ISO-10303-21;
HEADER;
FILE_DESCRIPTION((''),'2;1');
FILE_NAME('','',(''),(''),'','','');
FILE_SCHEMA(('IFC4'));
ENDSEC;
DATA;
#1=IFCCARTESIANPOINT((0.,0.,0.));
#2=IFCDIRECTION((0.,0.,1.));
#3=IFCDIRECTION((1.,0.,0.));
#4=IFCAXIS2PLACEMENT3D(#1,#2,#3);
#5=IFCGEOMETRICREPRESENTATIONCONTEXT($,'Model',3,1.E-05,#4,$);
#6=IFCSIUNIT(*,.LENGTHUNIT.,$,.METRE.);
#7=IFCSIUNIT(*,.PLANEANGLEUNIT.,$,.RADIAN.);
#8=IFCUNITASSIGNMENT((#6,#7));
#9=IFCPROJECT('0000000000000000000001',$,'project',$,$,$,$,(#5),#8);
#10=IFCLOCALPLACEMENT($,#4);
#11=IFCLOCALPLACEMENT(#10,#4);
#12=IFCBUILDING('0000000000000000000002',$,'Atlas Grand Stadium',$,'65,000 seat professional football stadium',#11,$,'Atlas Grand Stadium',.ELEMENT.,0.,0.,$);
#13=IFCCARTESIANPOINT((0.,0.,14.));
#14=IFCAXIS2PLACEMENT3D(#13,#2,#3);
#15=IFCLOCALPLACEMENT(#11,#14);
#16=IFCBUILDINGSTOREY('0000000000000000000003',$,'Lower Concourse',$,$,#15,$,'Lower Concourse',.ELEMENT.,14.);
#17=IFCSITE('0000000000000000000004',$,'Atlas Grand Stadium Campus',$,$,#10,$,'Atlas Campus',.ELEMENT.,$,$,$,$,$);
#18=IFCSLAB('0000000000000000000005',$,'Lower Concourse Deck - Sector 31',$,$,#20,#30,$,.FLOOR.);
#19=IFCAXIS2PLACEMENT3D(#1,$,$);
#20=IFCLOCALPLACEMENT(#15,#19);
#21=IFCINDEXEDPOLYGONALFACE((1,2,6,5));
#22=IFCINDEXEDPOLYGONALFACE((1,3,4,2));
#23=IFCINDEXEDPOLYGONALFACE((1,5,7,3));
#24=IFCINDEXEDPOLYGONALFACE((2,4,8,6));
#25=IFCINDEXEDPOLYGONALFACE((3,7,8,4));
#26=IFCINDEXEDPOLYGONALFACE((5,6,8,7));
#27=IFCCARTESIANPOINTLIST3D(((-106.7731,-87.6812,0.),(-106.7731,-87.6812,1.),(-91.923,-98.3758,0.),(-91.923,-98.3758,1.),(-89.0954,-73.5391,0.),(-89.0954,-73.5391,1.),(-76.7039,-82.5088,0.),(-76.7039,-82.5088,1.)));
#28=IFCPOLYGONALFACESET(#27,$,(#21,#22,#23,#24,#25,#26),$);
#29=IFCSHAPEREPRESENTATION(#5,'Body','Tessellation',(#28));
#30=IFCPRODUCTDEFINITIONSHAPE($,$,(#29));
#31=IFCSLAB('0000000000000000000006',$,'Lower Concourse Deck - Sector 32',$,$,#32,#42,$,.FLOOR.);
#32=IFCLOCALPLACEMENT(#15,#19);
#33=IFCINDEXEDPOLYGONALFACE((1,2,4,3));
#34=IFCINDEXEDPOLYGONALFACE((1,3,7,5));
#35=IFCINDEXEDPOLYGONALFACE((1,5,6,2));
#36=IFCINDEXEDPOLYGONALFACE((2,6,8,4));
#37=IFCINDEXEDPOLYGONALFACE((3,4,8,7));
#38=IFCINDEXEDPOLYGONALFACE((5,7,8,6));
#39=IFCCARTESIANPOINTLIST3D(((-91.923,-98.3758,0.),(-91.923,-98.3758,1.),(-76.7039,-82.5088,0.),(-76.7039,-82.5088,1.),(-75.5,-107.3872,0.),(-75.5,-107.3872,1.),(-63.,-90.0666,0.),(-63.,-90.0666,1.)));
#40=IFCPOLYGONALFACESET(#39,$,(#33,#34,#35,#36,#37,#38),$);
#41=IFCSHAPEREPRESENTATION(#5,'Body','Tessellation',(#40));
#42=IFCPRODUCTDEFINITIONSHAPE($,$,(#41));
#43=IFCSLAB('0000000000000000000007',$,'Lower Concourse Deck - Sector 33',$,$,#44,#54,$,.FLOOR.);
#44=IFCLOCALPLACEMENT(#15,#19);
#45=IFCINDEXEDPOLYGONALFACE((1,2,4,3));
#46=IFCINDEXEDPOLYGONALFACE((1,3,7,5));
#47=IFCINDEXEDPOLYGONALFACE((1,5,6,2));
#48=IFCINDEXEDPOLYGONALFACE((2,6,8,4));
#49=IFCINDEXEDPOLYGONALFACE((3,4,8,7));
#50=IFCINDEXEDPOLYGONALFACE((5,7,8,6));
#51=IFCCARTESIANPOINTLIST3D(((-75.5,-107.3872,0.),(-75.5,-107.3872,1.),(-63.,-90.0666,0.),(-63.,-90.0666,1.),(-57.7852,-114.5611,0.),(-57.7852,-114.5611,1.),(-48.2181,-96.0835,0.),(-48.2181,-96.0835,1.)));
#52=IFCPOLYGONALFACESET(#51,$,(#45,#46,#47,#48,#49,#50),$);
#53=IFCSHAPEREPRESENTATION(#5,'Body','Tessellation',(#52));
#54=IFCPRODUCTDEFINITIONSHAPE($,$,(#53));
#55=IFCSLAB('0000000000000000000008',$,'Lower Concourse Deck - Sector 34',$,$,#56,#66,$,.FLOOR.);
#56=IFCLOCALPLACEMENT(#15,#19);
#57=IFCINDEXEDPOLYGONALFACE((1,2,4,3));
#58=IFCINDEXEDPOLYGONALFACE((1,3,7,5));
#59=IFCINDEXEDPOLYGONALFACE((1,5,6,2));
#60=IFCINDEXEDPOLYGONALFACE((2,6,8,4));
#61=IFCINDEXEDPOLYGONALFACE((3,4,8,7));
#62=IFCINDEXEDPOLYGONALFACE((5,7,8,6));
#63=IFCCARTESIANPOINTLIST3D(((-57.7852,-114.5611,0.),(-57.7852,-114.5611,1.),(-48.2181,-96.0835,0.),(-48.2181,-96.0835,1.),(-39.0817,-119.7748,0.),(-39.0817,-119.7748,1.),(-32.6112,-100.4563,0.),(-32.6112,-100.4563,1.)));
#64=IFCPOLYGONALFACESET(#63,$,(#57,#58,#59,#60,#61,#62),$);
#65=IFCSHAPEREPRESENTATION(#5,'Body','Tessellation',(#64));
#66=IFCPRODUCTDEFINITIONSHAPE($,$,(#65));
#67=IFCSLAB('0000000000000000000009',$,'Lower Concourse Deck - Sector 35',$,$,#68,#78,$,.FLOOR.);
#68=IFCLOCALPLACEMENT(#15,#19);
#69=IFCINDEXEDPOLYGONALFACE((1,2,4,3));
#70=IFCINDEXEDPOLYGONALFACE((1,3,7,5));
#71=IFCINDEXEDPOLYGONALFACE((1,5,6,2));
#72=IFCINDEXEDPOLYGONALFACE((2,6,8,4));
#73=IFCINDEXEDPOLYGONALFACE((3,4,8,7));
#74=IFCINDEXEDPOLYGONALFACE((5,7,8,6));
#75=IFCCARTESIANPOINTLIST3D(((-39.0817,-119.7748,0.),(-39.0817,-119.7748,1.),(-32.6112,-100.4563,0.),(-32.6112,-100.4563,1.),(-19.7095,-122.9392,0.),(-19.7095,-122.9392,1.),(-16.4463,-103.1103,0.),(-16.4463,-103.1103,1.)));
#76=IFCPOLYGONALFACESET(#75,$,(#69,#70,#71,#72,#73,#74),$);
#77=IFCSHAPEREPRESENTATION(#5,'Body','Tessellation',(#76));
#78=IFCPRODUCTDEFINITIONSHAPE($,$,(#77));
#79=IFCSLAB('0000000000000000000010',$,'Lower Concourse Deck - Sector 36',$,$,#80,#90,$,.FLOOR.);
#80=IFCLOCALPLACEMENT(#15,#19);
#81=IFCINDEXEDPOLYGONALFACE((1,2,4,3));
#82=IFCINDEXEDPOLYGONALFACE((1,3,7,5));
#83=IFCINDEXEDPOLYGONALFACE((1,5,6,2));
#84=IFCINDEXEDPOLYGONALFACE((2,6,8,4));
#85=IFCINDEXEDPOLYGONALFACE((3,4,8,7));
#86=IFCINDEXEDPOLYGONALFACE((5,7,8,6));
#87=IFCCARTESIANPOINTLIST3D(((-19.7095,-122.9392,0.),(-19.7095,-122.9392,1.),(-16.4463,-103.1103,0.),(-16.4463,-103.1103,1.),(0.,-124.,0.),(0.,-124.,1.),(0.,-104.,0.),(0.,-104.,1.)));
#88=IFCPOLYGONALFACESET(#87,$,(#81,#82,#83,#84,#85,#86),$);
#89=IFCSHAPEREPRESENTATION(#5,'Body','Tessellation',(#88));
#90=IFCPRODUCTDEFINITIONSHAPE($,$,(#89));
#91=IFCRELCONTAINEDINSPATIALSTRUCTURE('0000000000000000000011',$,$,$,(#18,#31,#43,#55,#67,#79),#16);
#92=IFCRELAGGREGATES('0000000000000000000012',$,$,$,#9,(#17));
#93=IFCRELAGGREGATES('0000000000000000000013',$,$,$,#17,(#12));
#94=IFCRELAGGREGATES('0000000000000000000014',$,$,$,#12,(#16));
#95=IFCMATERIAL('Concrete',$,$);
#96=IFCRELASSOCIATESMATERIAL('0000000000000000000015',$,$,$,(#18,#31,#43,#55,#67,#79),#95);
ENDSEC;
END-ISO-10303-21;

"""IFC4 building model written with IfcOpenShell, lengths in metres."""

from ifc_helpers import new_model, si_unit, frame, origin_with_axes, place, context, project, spatial, polyline, outline, extrude, material, element, save


model = new_model("IFC4")

# Units and contexts
model_context = context("Model", 3, precision=1e-05, world=origin_with_axes())
ifc_project = project(units=[si_unit("LENGTHUNIT", "METRE"), si_unit("PLANEANGLEUNIT", "RADIAN")], contexts=[model_context])

# Site, building, storey
site_placement = place(None, origin_with_axes())
site = spatial("IfcSite", under=ifc_project, at=site_placement, Name="Atlas Grand Stadium Campus", LongName="Atlas Campus", CompositionType="ELEMENT")
building_placement = place(site_placement, origin_with_axes())
building = spatial("IfcBuilding", under=site, at=building_placement, Name="Atlas Grand Stadium", ObjectType="65,000 seat professional football stadium", LongName="Atlas Grand Stadium", CompositionType="ELEMENT", ElevationOfRefHeight=0.0, ElevationOfTerrain=0.0)
storey_placement = place(building_placement, frame((0.0, 0.0, 14.0), z_axis=(0.0, 0.0, 1.0), x_axis=(1.0, 0.0, 0.0)))
storey = spatial("IfcBuildingStorey", under=building, at=storey_placement, Name="Lower Concourse", LongName="Lower Concourse", CompositionType="ELEMENT", Elevation=14.0)

# Slabs
ifc_material = material(Name="Concrete")
slab_1_placement = place(storey_placement, origin_with_axes())
element("IfcSlab", 1, at=slab_1_placement, inside=storey, material=ifc_material, Name="Lower Concourse Deck - Sector 31", PredefinedType="FLOOR", context=model_context, shape_type="SweptSolid", body=[
    extrude(outline(polyline([(-106.7731, -87.6812), (-91.923, -98.3758), (-76.7039, -82.5088), (-89.0954, -73.5391), (-106.7731, -87.6812)])), origin_with_axes(), (0.0, 0.0, 1.0), 1.0),
])
slab_2_placement = place(storey_placement, origin_with_axes())
element("IfcSlab", 2, at=slab_2_placement, inside=storey, material=ifc_material, Name="Lower Concourse Deck - Sector 32", PredefinedType="FLOOR", context=model_context, shape_type="SweptSolid", body=[
    extrude(outline(polyline([(-91.923, -98.3758), (-75.5, -107.3872), (-63.0, -90.0666), (-76.7039, -82.5088), (-91.923, -98.3758)])), origin_with_axes(), (0.0, 0.0, 1.0), 1.0),
])
slab_3_placement = place(storey_placement, origin_with_axes())
element("IfcSlab", 3, at=slab_3_placement, inside=storey, material=ifc_material, Name="Lower Concourse Deck - Sector 33", PredefinedType="FLOOR", context=model_context, shape_type="SweptSolid", body=[
    extrude(outline(polyline([(-75.5, -107.3872), (-57.7852, -114.5611), (-48.2181, -96.0835), (-63.0, -90.0666), (-75.5, -107.3872)])), origin_with_axes(), (0.0, 0.0, 1.0), 1.0),
])
slab_4_placement = place(storey_placement, origin_with_axes())
element("IfcSlab", 4, at=slab_4_placement, inside=storey, material=ifc_material, Name="Lower Concourse Deck - Sector 34", PredefinedType="FLOOR", context=model_context, shape_type="SweptSolid", body=[
    extrude(outline(polyline([(-57.7852, -114.5611), (-39.0817, -119.7748), (-32.6112, -100.4563), (-48.2181, -96.0835), (-57.7852, -114.5611)])), origin_with_axes(), (0.0, 0.0, 1.0), 1.0),
])
slab_5_placement = place(storey_placement, origin_with_axes())
element("IfcSlab", 5, at=slab_5_placement, inside=storey, material=ifc_material, Name="Lower Concourse Deck - Sector 35", PredefinedType="FLOOR", context=model_context, shape_type="SweptSolid", body=[
    extrude(outline(polyline([(-39.0817, -119.7748), (-19.7095, -122.9392), (-16.4463, -103.1103), (-32.6112, -100.4563), (-39.0817, -119.7748)])), origin_with_axes(), (0.0, 0.0, 1.0), 1.0),
])
slab_6_placement = place(storey_placement, origin_with_axes())
element("IfcSlab", 6, at=slab_6_placement, inside=storey, material=ifc_material, Name="Lower Concourse Deck - Sector 36", PredefinedType="FLOOR", context=model_context, shape_type="SweptSolid", body=[
    extrude(outline(polyline([(-19.7095, -122.9392), (0.0, -124.0), (0.0, -104.0), (-16.4463, -103.1103), (-19.7095, -122.9392)])), origin_with_axes(), (0.0, 0.0, 1.0), 1.0),
])

save(model, "model.ifc")
